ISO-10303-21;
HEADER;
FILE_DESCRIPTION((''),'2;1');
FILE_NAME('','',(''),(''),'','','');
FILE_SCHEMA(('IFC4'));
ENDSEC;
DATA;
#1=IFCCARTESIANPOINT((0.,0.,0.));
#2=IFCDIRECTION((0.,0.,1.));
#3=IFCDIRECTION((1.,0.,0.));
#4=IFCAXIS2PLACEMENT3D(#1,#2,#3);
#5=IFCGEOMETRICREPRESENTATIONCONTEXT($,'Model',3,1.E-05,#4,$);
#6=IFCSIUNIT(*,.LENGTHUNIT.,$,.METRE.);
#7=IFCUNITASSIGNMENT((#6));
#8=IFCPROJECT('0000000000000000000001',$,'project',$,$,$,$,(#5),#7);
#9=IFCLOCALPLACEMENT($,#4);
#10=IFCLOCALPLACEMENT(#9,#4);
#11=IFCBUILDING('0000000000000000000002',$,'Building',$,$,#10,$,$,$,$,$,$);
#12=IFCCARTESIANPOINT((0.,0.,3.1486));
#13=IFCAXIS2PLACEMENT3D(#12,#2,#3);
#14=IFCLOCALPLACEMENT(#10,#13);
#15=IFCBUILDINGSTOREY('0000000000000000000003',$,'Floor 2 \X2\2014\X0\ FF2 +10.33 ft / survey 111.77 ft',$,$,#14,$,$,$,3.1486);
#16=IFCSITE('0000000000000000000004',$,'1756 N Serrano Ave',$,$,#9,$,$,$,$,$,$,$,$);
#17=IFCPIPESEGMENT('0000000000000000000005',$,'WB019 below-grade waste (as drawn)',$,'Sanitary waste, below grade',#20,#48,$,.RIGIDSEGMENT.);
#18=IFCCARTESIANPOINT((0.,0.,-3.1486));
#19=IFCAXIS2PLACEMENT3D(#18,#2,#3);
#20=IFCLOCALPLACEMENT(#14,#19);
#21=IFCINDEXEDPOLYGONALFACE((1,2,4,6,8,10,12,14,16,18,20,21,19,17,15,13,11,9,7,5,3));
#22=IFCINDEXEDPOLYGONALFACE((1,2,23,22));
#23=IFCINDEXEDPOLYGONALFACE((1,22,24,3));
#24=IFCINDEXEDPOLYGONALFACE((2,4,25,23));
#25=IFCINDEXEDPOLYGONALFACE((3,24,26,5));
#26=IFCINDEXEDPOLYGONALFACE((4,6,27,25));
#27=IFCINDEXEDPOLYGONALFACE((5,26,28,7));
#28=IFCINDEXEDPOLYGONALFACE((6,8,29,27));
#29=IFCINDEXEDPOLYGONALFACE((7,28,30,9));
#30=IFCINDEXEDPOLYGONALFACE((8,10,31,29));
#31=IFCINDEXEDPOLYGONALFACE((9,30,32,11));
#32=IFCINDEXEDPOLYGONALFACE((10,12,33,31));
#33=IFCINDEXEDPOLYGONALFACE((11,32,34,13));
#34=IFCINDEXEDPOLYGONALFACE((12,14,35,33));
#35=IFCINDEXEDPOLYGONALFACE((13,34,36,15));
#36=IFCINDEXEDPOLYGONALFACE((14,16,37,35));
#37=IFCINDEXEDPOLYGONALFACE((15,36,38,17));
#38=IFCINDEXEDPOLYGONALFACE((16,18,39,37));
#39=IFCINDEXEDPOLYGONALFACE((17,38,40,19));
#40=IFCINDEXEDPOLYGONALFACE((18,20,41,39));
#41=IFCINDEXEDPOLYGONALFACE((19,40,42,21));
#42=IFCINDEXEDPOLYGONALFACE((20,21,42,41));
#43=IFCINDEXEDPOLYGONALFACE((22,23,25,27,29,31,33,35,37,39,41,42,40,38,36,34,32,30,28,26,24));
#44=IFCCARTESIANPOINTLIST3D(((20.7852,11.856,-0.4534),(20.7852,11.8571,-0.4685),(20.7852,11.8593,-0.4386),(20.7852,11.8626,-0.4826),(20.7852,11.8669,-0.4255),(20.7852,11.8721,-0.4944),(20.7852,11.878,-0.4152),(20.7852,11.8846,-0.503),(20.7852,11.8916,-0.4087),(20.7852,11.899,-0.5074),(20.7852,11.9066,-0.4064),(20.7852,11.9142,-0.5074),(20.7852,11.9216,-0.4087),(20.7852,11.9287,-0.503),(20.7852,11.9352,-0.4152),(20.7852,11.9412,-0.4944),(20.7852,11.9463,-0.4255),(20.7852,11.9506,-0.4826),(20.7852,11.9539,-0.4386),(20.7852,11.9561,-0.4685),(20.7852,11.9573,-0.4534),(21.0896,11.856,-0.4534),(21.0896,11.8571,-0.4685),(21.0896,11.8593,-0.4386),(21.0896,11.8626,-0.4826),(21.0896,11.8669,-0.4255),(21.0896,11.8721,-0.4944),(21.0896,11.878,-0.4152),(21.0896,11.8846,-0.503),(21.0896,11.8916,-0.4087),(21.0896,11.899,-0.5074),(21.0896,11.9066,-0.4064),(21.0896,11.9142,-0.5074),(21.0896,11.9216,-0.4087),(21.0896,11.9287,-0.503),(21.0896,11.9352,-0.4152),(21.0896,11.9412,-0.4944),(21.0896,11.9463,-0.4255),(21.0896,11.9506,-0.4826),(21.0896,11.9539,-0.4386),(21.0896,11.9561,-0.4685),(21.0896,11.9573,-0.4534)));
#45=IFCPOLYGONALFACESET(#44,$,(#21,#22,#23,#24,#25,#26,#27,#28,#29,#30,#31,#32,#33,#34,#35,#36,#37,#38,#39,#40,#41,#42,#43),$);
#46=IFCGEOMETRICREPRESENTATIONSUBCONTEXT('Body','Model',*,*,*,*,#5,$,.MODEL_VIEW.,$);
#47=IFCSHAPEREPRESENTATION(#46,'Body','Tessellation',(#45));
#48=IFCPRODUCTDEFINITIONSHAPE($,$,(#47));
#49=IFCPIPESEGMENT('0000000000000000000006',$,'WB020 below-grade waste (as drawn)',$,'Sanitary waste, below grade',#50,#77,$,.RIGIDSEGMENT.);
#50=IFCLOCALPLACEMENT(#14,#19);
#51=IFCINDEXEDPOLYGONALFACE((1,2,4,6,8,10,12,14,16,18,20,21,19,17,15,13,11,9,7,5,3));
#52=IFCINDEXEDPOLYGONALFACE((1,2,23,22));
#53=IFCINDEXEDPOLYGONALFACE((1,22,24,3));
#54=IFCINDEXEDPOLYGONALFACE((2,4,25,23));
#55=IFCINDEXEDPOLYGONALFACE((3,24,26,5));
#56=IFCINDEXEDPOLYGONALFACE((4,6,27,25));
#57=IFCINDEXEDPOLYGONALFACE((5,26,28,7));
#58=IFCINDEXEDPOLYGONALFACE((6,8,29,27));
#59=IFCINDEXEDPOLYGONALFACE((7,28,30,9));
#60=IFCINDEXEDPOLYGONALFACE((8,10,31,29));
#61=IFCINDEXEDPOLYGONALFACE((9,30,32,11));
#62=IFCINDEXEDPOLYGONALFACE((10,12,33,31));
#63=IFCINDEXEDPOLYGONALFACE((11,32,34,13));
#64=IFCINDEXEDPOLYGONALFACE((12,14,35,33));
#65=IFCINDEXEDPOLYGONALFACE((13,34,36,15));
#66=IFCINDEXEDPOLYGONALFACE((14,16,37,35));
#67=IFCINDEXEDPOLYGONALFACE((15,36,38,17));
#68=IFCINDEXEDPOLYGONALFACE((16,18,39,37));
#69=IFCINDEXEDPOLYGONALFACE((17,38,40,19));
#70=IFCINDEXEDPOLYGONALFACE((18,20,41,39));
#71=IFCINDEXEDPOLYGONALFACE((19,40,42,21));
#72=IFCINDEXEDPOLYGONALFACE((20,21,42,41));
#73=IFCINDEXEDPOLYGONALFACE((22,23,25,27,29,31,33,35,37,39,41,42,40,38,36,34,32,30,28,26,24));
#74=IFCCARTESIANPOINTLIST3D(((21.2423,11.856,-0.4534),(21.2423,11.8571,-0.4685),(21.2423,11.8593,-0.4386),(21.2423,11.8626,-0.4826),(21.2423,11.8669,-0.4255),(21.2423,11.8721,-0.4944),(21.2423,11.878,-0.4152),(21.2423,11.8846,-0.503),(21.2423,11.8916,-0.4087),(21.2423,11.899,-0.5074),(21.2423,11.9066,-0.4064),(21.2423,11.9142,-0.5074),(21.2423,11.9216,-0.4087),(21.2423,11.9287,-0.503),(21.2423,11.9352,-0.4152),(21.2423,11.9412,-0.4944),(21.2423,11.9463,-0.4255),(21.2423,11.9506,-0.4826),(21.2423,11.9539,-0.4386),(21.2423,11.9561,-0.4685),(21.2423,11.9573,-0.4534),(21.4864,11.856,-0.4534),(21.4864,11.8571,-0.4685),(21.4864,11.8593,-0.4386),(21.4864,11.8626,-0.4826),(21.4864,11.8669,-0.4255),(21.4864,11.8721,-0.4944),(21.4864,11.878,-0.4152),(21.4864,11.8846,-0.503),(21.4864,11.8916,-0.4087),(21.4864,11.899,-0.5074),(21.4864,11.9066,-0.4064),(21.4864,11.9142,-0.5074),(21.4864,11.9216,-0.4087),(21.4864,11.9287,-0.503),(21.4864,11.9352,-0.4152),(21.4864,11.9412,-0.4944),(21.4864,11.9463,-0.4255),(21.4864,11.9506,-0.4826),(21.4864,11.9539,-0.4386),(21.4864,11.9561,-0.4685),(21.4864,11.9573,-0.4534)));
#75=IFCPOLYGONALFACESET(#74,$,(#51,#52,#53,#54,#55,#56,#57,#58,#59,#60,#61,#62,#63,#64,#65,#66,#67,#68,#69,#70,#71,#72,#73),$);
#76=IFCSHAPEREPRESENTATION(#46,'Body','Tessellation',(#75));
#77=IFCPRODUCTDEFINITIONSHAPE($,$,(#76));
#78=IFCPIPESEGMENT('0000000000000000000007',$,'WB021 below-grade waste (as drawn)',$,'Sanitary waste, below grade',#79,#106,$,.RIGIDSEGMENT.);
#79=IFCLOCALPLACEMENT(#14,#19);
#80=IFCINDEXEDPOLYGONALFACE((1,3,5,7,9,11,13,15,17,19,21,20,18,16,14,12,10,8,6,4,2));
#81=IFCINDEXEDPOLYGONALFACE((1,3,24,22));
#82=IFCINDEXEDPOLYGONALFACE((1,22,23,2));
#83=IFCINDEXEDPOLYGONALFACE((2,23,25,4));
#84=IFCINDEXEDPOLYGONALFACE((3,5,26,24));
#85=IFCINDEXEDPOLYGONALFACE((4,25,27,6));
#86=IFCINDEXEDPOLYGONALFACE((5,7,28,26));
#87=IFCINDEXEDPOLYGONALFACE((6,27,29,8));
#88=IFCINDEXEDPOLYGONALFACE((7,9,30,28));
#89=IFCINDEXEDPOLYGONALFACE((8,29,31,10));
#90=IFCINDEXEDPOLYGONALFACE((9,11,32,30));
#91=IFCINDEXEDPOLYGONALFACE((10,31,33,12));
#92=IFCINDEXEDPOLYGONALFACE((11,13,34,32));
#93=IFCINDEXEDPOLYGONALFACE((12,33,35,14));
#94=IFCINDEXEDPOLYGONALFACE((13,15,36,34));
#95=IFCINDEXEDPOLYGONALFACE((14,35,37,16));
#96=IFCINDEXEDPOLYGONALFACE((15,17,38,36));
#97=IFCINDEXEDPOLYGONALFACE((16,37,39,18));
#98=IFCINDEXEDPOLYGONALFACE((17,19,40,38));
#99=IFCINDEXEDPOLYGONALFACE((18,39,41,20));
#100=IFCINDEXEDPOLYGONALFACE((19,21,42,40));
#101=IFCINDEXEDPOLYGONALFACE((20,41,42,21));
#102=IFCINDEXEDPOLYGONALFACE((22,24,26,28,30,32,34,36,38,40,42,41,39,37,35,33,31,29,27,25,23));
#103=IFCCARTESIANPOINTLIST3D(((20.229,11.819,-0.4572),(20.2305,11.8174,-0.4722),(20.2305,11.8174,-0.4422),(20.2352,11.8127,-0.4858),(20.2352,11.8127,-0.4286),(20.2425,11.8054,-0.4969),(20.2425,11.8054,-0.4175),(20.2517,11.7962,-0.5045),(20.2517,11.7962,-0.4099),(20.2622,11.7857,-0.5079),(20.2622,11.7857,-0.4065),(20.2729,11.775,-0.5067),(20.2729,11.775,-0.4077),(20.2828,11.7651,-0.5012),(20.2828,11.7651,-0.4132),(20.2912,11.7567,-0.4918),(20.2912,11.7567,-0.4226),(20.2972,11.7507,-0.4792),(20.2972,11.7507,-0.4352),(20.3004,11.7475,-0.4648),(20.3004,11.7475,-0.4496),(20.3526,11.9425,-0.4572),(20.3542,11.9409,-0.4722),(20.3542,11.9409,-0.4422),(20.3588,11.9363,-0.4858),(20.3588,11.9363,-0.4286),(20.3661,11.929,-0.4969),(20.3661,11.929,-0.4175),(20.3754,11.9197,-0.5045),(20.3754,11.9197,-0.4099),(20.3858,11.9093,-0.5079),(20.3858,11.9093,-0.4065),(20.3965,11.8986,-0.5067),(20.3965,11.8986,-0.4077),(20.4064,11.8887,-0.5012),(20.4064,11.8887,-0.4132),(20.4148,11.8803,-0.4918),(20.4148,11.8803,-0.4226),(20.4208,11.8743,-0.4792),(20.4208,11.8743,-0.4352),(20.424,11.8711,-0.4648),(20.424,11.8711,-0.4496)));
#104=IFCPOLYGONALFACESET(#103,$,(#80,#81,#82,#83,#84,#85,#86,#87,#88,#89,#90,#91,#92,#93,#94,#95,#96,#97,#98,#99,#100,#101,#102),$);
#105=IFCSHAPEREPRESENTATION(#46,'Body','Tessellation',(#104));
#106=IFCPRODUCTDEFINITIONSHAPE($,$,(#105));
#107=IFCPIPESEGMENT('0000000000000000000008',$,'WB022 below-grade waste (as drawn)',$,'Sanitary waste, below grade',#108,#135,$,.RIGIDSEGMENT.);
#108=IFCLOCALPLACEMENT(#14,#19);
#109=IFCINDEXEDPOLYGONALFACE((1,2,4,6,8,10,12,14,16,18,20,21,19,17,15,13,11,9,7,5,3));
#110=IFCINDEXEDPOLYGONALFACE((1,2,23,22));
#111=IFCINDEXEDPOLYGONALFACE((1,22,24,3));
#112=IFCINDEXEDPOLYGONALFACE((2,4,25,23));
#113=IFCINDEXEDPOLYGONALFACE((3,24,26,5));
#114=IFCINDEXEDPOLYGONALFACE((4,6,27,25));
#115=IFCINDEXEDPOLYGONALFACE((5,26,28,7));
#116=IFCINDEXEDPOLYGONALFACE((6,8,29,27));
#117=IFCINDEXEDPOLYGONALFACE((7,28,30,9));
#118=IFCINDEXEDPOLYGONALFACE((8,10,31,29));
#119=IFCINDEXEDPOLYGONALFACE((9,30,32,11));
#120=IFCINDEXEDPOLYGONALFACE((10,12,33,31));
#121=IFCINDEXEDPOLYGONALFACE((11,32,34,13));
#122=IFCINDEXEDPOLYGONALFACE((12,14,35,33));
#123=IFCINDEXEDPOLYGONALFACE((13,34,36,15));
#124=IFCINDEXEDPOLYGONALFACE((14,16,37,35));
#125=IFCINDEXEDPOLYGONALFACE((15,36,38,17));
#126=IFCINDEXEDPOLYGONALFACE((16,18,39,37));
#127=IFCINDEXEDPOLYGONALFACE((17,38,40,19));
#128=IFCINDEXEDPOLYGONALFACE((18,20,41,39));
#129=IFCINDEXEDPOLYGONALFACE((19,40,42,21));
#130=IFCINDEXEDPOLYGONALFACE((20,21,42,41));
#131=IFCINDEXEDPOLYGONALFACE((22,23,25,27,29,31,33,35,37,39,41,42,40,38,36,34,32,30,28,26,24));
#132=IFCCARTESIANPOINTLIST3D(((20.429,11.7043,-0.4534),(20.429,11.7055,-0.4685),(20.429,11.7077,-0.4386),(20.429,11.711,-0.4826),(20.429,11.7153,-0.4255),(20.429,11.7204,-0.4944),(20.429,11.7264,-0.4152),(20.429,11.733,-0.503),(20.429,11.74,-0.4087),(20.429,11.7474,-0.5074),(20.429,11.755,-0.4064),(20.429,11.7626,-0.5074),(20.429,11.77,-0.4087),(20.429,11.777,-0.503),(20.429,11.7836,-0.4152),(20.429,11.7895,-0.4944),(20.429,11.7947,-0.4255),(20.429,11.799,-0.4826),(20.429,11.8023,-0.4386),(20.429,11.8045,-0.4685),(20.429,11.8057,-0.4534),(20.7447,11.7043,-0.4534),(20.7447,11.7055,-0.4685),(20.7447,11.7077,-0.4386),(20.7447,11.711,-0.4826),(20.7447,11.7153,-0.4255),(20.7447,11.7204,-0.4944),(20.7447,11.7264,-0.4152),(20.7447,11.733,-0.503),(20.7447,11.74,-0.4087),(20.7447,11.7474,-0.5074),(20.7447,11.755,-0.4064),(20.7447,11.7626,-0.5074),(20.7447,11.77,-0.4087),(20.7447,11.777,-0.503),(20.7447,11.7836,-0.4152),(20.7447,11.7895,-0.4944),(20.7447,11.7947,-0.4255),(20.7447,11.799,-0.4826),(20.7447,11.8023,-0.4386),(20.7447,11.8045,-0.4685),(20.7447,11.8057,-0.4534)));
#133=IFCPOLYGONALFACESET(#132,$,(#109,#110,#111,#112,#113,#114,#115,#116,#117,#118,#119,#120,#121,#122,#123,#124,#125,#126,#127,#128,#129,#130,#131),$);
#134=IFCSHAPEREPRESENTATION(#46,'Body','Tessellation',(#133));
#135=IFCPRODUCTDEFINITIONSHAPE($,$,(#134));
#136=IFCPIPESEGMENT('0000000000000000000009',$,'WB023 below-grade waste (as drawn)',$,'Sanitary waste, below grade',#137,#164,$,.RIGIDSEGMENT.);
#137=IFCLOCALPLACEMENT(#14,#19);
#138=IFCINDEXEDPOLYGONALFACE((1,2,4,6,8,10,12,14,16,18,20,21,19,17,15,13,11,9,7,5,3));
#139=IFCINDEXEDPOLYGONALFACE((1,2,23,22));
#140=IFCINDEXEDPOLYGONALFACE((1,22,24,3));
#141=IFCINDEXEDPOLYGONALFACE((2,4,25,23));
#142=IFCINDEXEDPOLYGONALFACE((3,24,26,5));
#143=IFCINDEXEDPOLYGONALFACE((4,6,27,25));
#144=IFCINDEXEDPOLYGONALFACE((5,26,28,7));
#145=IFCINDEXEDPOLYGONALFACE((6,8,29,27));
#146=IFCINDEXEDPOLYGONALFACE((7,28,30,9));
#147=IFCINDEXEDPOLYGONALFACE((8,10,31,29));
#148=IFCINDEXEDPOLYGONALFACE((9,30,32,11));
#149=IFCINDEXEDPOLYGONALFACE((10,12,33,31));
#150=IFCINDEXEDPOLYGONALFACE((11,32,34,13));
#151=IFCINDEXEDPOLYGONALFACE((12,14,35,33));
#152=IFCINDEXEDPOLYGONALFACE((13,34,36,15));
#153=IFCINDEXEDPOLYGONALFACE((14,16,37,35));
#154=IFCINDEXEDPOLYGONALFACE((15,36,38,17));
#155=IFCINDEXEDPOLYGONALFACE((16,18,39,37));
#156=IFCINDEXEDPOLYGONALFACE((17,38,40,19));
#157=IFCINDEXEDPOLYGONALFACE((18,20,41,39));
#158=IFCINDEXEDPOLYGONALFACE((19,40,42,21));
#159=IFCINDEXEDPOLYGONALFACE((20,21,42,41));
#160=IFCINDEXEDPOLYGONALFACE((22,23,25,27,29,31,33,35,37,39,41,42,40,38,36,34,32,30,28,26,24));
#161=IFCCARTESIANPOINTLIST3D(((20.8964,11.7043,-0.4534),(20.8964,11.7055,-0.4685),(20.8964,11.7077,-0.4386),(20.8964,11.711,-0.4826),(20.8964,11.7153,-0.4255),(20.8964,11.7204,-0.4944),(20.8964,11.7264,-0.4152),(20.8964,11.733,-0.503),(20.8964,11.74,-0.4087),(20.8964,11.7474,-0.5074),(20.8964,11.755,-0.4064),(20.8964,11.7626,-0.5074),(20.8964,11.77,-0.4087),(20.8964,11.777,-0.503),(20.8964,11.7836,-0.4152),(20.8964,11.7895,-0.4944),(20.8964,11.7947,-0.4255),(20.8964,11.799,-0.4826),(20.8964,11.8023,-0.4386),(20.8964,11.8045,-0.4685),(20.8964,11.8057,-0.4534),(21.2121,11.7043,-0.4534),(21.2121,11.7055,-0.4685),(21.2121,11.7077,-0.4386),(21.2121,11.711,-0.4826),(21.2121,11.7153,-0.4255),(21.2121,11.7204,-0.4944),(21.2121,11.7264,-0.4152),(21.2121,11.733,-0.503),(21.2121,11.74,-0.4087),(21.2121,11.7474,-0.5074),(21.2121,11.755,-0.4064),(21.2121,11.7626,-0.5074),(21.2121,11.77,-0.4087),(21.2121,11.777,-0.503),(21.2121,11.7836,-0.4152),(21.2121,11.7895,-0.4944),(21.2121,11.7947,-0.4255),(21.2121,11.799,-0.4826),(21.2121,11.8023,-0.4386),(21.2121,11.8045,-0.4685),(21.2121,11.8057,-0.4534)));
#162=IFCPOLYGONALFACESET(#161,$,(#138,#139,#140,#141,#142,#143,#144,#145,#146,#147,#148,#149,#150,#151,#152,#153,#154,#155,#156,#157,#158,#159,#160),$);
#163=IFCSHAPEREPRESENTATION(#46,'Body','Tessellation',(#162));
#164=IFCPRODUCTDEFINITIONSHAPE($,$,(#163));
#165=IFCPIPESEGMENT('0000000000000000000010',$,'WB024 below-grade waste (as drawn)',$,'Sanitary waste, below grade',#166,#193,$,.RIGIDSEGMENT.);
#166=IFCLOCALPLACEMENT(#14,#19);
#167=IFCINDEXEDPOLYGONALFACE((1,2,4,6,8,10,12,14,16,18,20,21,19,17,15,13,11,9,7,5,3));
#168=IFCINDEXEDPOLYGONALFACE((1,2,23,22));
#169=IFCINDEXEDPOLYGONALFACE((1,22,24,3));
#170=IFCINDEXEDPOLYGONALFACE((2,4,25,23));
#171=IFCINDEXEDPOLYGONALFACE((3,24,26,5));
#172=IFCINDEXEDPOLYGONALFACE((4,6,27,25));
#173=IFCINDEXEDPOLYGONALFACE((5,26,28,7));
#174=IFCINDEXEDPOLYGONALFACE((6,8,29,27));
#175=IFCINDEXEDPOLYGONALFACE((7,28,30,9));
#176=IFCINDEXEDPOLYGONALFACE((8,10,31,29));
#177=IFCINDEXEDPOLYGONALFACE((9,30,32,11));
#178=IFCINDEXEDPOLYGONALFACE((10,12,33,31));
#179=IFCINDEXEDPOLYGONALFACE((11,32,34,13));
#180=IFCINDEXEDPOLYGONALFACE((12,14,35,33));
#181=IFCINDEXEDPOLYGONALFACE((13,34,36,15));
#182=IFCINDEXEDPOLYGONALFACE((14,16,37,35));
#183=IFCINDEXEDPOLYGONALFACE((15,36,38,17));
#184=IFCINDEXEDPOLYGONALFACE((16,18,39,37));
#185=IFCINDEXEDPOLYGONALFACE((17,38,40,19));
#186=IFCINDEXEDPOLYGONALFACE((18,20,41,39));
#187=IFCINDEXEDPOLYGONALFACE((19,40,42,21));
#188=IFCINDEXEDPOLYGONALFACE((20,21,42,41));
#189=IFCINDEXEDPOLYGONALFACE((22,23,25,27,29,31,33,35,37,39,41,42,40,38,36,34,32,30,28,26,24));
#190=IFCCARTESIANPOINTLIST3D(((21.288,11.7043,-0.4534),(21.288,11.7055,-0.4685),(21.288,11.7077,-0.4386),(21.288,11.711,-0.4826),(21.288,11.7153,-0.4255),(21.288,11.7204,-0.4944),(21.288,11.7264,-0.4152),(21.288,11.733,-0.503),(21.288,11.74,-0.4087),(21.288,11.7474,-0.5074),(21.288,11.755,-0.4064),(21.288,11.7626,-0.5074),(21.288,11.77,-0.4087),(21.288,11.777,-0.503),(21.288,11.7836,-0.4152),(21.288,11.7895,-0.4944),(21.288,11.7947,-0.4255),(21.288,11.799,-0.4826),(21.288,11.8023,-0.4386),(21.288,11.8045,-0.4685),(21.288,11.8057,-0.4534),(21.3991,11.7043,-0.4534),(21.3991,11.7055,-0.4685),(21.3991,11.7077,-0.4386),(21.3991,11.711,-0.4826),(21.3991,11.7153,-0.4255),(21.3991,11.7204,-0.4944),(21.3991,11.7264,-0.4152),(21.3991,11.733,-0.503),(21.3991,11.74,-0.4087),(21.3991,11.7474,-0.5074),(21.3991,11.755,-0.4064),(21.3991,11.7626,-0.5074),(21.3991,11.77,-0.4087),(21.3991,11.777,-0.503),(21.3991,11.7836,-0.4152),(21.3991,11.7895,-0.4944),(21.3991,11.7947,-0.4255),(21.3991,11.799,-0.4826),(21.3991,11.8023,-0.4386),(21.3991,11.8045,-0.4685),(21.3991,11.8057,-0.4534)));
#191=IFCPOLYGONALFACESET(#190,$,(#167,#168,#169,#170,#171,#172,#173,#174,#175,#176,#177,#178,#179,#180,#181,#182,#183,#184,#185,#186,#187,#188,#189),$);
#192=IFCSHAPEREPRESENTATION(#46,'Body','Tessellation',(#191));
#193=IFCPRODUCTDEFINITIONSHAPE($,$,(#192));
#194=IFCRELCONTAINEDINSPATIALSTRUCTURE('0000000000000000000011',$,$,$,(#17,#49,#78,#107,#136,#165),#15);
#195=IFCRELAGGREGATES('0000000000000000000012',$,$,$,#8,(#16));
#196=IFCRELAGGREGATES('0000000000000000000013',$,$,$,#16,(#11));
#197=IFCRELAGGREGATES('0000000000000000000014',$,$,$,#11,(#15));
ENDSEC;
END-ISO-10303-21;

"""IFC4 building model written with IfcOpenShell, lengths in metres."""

from ifc_helpers import new_model, entity, si_unit, frame, origin_with_axes, place, context, subcontext, project, spatial, element, save


model = new_model("IFC4")

# Units and contexts
model_context = context("Model", 3, precision=1e-05, world=origin_with_axes())
body_context = subcontext(model_context, "Body", "Model", "MODEL_VIEW")
ifc_project = project(units=[si_unit("LENGTHUNIT", "METRE")], contexts=[model_context])

# Site, building, storey
site_placement = place(None, origin_with_axes())
site = spatial("IfcSite", under=ifc_project, at=site_placement, Name="1756 N Serrano Ave")
building_placement = place(site_placement, origin_with_axes())
building = spatial("IfcBuilding", under=site, at=building_placement, Name="Building")
storey_placement = place(building_placement, frame((0.0, 0.0, 3.1486), z_axis=(0.0, 0.0, 1.0), x_axis=(1.0, 0.0, 0.0)))
storey = spatial("IfcBuildingStorey", under=building, at=storey_placement, Name="Floor 2 — FF2 +10.33 ft / survey 111.77 ft", Elevation=3.1486)

# Pipe segments
pipe_segment_1_placement = place(storey_placement, frame((0.0, 0.0, -3.1486), z_axis=(0.0, 0.0, 1.0), x_axis=(1.0, 0.0, 0.0)))
element("IfcPipeSegment", 1, at=pipe_segment_1_placement, inside=storey, Name="WB019 below-grade waste (as drawn)", ObjectType="Sanitary waste, below grade", PredefinedType="RIGIDSEGMENT", context=body_context, shape_type="AdvancedSweptSolid", body=[
    entity("IfcSweptDiskSolid", entity("IfcPolyline", [entity("IfcCartesianPoint", [20.7852, 11.9066, -0.4572]), entity("IfcCartesianPoint", [21.0896, 11.9066, -0.4572])]), 0.0508),
])
pipe_segment_2_placement = place(storey_placement, frame((0.0, 0.0, -3.1486), z_axis=(0.0, 0.0, 1.0), x_axis=(1.0, 0.0, 0.0)))
element("IfcPipeSegment", 2, at=pipe_segment_2_placement, inside=storey, Name="WB020 below-grade waste (as drawn)", ObjectType="Sanitary waste, below grade", PredefinedType="RIGIDSEGMENT", context=body_context, shape_type="AdvancedSweptSolid", body=[
    entity("IfcSweptDiskSolid", entity("IfcPolyline", [entity("IfcCartesianPoint", [21.2423, 11.9066, -0.4572]), entity("IfcCartesianPoint", [21.4864, 11.9066, -0.4572])]), 0.0508),
])
pipe_segment_3_placement = place(storey_placement, frame((0.0, 0.0, -3.1486), z_axis=(0.0, 0.0, 1.0), x_axis=(1.0, 0.0, 0.0)))
element("IfcPipeSegment", 3, at=pipe_segment_3_placement, inside=storey, Name="WB021 below-grade waste (as drawn)", ObjectType="Sanitary waste, below grade", PredefinedType="RIGIDSEGMENT", context=body_context, shape_type="AdvancedSweptSolid", body=[
    entity("IfcSweptDiskSolid", entity("IfcPolyline", [entity("IfcCartesianPoint", [20.2649, 11.783, -0.4572]), entity("IfcCartesianPoint", [20.3885, 11.9066, -0.4572])]), 0.0508),
])
pipe_segment_4_placement = place(storey_placement, frame((0.0, 0.0, -3.1486), z_axis=(0.0, 0.0, 1.0), x_axis=(1.0, 0.0, 0.0)))
element("IfcPipeSegment", 4, at=pipe_segment_4_placement, inside=storey, Name="WB022 below-grade waste (as drawn)", ObjectType="Sanitary waste, below grade", PredefinedType="RIGIDSEGMENT", context=body_context, shape_type="AdvancedSweptSolid", body=[
    entity("IfcSweptDiskSolid", entity("IfcPolyline", [entity("IfcCartesianPoint", [20.429, 11.755, -0.4572]), entity("IfcCartesianPoint", [20.7447, 11.755, -0.4572])]), 0.0508),
])
pipe_segment_5_placement = place(storey_placement, frame((0.0, 0.0, -3.1486), z_axis=(0.0, 0.0, 1.0), x_axis=(1.0, 0.0, 0.0)))
element("IfcPipeSegment", 5, at=pipe_segment_5_placement, inside=storey, Name="WB023 below-grade waste (as drawn)", ObjectType="Sanitary waste, below grade", PredefinedType="RIGIDSEGMENT", context=body_context, shape_type="AdvancedSweptSolid", body=[
    entity("IfcSweptDiskSolid", entity("IfcPolyline", [entity("IfcCartesianPoint", [20.8964, 11.755, -0.4572]), entity("IfcCartesianPoint", [21.2121, 11.755, -0.4572])]), 0.0508),
])
pipe_segment_6_placement = place(storey_placement, frame((0.0, 0.0, -3.1486), z_axis=(0.0, 0.0, 1.0), x_axis=(1.0, 0.0, 0.0)))
element("IfcPipeSegment", 6, at=pipe_segment_6_placement, inside=storey, Name="WB024 below-grade waste (as drawn)", ObjectType="Sanitary waste, below grade", PredefinedType="RIGIDSEGMENT", context=body_context, shape_type="AdvancedSweptSolid", body=[
    entity("IfcSweptDiskSolid", entity("IfcPolyline", [entity("IfcCartesianPoint", [21.288, 11.755, -0.4572]), entity("IfcCartesianPoint", [21.3991, 11.755, -0.4572])]), 0.0508),
])

save(model, "model.ifc")
